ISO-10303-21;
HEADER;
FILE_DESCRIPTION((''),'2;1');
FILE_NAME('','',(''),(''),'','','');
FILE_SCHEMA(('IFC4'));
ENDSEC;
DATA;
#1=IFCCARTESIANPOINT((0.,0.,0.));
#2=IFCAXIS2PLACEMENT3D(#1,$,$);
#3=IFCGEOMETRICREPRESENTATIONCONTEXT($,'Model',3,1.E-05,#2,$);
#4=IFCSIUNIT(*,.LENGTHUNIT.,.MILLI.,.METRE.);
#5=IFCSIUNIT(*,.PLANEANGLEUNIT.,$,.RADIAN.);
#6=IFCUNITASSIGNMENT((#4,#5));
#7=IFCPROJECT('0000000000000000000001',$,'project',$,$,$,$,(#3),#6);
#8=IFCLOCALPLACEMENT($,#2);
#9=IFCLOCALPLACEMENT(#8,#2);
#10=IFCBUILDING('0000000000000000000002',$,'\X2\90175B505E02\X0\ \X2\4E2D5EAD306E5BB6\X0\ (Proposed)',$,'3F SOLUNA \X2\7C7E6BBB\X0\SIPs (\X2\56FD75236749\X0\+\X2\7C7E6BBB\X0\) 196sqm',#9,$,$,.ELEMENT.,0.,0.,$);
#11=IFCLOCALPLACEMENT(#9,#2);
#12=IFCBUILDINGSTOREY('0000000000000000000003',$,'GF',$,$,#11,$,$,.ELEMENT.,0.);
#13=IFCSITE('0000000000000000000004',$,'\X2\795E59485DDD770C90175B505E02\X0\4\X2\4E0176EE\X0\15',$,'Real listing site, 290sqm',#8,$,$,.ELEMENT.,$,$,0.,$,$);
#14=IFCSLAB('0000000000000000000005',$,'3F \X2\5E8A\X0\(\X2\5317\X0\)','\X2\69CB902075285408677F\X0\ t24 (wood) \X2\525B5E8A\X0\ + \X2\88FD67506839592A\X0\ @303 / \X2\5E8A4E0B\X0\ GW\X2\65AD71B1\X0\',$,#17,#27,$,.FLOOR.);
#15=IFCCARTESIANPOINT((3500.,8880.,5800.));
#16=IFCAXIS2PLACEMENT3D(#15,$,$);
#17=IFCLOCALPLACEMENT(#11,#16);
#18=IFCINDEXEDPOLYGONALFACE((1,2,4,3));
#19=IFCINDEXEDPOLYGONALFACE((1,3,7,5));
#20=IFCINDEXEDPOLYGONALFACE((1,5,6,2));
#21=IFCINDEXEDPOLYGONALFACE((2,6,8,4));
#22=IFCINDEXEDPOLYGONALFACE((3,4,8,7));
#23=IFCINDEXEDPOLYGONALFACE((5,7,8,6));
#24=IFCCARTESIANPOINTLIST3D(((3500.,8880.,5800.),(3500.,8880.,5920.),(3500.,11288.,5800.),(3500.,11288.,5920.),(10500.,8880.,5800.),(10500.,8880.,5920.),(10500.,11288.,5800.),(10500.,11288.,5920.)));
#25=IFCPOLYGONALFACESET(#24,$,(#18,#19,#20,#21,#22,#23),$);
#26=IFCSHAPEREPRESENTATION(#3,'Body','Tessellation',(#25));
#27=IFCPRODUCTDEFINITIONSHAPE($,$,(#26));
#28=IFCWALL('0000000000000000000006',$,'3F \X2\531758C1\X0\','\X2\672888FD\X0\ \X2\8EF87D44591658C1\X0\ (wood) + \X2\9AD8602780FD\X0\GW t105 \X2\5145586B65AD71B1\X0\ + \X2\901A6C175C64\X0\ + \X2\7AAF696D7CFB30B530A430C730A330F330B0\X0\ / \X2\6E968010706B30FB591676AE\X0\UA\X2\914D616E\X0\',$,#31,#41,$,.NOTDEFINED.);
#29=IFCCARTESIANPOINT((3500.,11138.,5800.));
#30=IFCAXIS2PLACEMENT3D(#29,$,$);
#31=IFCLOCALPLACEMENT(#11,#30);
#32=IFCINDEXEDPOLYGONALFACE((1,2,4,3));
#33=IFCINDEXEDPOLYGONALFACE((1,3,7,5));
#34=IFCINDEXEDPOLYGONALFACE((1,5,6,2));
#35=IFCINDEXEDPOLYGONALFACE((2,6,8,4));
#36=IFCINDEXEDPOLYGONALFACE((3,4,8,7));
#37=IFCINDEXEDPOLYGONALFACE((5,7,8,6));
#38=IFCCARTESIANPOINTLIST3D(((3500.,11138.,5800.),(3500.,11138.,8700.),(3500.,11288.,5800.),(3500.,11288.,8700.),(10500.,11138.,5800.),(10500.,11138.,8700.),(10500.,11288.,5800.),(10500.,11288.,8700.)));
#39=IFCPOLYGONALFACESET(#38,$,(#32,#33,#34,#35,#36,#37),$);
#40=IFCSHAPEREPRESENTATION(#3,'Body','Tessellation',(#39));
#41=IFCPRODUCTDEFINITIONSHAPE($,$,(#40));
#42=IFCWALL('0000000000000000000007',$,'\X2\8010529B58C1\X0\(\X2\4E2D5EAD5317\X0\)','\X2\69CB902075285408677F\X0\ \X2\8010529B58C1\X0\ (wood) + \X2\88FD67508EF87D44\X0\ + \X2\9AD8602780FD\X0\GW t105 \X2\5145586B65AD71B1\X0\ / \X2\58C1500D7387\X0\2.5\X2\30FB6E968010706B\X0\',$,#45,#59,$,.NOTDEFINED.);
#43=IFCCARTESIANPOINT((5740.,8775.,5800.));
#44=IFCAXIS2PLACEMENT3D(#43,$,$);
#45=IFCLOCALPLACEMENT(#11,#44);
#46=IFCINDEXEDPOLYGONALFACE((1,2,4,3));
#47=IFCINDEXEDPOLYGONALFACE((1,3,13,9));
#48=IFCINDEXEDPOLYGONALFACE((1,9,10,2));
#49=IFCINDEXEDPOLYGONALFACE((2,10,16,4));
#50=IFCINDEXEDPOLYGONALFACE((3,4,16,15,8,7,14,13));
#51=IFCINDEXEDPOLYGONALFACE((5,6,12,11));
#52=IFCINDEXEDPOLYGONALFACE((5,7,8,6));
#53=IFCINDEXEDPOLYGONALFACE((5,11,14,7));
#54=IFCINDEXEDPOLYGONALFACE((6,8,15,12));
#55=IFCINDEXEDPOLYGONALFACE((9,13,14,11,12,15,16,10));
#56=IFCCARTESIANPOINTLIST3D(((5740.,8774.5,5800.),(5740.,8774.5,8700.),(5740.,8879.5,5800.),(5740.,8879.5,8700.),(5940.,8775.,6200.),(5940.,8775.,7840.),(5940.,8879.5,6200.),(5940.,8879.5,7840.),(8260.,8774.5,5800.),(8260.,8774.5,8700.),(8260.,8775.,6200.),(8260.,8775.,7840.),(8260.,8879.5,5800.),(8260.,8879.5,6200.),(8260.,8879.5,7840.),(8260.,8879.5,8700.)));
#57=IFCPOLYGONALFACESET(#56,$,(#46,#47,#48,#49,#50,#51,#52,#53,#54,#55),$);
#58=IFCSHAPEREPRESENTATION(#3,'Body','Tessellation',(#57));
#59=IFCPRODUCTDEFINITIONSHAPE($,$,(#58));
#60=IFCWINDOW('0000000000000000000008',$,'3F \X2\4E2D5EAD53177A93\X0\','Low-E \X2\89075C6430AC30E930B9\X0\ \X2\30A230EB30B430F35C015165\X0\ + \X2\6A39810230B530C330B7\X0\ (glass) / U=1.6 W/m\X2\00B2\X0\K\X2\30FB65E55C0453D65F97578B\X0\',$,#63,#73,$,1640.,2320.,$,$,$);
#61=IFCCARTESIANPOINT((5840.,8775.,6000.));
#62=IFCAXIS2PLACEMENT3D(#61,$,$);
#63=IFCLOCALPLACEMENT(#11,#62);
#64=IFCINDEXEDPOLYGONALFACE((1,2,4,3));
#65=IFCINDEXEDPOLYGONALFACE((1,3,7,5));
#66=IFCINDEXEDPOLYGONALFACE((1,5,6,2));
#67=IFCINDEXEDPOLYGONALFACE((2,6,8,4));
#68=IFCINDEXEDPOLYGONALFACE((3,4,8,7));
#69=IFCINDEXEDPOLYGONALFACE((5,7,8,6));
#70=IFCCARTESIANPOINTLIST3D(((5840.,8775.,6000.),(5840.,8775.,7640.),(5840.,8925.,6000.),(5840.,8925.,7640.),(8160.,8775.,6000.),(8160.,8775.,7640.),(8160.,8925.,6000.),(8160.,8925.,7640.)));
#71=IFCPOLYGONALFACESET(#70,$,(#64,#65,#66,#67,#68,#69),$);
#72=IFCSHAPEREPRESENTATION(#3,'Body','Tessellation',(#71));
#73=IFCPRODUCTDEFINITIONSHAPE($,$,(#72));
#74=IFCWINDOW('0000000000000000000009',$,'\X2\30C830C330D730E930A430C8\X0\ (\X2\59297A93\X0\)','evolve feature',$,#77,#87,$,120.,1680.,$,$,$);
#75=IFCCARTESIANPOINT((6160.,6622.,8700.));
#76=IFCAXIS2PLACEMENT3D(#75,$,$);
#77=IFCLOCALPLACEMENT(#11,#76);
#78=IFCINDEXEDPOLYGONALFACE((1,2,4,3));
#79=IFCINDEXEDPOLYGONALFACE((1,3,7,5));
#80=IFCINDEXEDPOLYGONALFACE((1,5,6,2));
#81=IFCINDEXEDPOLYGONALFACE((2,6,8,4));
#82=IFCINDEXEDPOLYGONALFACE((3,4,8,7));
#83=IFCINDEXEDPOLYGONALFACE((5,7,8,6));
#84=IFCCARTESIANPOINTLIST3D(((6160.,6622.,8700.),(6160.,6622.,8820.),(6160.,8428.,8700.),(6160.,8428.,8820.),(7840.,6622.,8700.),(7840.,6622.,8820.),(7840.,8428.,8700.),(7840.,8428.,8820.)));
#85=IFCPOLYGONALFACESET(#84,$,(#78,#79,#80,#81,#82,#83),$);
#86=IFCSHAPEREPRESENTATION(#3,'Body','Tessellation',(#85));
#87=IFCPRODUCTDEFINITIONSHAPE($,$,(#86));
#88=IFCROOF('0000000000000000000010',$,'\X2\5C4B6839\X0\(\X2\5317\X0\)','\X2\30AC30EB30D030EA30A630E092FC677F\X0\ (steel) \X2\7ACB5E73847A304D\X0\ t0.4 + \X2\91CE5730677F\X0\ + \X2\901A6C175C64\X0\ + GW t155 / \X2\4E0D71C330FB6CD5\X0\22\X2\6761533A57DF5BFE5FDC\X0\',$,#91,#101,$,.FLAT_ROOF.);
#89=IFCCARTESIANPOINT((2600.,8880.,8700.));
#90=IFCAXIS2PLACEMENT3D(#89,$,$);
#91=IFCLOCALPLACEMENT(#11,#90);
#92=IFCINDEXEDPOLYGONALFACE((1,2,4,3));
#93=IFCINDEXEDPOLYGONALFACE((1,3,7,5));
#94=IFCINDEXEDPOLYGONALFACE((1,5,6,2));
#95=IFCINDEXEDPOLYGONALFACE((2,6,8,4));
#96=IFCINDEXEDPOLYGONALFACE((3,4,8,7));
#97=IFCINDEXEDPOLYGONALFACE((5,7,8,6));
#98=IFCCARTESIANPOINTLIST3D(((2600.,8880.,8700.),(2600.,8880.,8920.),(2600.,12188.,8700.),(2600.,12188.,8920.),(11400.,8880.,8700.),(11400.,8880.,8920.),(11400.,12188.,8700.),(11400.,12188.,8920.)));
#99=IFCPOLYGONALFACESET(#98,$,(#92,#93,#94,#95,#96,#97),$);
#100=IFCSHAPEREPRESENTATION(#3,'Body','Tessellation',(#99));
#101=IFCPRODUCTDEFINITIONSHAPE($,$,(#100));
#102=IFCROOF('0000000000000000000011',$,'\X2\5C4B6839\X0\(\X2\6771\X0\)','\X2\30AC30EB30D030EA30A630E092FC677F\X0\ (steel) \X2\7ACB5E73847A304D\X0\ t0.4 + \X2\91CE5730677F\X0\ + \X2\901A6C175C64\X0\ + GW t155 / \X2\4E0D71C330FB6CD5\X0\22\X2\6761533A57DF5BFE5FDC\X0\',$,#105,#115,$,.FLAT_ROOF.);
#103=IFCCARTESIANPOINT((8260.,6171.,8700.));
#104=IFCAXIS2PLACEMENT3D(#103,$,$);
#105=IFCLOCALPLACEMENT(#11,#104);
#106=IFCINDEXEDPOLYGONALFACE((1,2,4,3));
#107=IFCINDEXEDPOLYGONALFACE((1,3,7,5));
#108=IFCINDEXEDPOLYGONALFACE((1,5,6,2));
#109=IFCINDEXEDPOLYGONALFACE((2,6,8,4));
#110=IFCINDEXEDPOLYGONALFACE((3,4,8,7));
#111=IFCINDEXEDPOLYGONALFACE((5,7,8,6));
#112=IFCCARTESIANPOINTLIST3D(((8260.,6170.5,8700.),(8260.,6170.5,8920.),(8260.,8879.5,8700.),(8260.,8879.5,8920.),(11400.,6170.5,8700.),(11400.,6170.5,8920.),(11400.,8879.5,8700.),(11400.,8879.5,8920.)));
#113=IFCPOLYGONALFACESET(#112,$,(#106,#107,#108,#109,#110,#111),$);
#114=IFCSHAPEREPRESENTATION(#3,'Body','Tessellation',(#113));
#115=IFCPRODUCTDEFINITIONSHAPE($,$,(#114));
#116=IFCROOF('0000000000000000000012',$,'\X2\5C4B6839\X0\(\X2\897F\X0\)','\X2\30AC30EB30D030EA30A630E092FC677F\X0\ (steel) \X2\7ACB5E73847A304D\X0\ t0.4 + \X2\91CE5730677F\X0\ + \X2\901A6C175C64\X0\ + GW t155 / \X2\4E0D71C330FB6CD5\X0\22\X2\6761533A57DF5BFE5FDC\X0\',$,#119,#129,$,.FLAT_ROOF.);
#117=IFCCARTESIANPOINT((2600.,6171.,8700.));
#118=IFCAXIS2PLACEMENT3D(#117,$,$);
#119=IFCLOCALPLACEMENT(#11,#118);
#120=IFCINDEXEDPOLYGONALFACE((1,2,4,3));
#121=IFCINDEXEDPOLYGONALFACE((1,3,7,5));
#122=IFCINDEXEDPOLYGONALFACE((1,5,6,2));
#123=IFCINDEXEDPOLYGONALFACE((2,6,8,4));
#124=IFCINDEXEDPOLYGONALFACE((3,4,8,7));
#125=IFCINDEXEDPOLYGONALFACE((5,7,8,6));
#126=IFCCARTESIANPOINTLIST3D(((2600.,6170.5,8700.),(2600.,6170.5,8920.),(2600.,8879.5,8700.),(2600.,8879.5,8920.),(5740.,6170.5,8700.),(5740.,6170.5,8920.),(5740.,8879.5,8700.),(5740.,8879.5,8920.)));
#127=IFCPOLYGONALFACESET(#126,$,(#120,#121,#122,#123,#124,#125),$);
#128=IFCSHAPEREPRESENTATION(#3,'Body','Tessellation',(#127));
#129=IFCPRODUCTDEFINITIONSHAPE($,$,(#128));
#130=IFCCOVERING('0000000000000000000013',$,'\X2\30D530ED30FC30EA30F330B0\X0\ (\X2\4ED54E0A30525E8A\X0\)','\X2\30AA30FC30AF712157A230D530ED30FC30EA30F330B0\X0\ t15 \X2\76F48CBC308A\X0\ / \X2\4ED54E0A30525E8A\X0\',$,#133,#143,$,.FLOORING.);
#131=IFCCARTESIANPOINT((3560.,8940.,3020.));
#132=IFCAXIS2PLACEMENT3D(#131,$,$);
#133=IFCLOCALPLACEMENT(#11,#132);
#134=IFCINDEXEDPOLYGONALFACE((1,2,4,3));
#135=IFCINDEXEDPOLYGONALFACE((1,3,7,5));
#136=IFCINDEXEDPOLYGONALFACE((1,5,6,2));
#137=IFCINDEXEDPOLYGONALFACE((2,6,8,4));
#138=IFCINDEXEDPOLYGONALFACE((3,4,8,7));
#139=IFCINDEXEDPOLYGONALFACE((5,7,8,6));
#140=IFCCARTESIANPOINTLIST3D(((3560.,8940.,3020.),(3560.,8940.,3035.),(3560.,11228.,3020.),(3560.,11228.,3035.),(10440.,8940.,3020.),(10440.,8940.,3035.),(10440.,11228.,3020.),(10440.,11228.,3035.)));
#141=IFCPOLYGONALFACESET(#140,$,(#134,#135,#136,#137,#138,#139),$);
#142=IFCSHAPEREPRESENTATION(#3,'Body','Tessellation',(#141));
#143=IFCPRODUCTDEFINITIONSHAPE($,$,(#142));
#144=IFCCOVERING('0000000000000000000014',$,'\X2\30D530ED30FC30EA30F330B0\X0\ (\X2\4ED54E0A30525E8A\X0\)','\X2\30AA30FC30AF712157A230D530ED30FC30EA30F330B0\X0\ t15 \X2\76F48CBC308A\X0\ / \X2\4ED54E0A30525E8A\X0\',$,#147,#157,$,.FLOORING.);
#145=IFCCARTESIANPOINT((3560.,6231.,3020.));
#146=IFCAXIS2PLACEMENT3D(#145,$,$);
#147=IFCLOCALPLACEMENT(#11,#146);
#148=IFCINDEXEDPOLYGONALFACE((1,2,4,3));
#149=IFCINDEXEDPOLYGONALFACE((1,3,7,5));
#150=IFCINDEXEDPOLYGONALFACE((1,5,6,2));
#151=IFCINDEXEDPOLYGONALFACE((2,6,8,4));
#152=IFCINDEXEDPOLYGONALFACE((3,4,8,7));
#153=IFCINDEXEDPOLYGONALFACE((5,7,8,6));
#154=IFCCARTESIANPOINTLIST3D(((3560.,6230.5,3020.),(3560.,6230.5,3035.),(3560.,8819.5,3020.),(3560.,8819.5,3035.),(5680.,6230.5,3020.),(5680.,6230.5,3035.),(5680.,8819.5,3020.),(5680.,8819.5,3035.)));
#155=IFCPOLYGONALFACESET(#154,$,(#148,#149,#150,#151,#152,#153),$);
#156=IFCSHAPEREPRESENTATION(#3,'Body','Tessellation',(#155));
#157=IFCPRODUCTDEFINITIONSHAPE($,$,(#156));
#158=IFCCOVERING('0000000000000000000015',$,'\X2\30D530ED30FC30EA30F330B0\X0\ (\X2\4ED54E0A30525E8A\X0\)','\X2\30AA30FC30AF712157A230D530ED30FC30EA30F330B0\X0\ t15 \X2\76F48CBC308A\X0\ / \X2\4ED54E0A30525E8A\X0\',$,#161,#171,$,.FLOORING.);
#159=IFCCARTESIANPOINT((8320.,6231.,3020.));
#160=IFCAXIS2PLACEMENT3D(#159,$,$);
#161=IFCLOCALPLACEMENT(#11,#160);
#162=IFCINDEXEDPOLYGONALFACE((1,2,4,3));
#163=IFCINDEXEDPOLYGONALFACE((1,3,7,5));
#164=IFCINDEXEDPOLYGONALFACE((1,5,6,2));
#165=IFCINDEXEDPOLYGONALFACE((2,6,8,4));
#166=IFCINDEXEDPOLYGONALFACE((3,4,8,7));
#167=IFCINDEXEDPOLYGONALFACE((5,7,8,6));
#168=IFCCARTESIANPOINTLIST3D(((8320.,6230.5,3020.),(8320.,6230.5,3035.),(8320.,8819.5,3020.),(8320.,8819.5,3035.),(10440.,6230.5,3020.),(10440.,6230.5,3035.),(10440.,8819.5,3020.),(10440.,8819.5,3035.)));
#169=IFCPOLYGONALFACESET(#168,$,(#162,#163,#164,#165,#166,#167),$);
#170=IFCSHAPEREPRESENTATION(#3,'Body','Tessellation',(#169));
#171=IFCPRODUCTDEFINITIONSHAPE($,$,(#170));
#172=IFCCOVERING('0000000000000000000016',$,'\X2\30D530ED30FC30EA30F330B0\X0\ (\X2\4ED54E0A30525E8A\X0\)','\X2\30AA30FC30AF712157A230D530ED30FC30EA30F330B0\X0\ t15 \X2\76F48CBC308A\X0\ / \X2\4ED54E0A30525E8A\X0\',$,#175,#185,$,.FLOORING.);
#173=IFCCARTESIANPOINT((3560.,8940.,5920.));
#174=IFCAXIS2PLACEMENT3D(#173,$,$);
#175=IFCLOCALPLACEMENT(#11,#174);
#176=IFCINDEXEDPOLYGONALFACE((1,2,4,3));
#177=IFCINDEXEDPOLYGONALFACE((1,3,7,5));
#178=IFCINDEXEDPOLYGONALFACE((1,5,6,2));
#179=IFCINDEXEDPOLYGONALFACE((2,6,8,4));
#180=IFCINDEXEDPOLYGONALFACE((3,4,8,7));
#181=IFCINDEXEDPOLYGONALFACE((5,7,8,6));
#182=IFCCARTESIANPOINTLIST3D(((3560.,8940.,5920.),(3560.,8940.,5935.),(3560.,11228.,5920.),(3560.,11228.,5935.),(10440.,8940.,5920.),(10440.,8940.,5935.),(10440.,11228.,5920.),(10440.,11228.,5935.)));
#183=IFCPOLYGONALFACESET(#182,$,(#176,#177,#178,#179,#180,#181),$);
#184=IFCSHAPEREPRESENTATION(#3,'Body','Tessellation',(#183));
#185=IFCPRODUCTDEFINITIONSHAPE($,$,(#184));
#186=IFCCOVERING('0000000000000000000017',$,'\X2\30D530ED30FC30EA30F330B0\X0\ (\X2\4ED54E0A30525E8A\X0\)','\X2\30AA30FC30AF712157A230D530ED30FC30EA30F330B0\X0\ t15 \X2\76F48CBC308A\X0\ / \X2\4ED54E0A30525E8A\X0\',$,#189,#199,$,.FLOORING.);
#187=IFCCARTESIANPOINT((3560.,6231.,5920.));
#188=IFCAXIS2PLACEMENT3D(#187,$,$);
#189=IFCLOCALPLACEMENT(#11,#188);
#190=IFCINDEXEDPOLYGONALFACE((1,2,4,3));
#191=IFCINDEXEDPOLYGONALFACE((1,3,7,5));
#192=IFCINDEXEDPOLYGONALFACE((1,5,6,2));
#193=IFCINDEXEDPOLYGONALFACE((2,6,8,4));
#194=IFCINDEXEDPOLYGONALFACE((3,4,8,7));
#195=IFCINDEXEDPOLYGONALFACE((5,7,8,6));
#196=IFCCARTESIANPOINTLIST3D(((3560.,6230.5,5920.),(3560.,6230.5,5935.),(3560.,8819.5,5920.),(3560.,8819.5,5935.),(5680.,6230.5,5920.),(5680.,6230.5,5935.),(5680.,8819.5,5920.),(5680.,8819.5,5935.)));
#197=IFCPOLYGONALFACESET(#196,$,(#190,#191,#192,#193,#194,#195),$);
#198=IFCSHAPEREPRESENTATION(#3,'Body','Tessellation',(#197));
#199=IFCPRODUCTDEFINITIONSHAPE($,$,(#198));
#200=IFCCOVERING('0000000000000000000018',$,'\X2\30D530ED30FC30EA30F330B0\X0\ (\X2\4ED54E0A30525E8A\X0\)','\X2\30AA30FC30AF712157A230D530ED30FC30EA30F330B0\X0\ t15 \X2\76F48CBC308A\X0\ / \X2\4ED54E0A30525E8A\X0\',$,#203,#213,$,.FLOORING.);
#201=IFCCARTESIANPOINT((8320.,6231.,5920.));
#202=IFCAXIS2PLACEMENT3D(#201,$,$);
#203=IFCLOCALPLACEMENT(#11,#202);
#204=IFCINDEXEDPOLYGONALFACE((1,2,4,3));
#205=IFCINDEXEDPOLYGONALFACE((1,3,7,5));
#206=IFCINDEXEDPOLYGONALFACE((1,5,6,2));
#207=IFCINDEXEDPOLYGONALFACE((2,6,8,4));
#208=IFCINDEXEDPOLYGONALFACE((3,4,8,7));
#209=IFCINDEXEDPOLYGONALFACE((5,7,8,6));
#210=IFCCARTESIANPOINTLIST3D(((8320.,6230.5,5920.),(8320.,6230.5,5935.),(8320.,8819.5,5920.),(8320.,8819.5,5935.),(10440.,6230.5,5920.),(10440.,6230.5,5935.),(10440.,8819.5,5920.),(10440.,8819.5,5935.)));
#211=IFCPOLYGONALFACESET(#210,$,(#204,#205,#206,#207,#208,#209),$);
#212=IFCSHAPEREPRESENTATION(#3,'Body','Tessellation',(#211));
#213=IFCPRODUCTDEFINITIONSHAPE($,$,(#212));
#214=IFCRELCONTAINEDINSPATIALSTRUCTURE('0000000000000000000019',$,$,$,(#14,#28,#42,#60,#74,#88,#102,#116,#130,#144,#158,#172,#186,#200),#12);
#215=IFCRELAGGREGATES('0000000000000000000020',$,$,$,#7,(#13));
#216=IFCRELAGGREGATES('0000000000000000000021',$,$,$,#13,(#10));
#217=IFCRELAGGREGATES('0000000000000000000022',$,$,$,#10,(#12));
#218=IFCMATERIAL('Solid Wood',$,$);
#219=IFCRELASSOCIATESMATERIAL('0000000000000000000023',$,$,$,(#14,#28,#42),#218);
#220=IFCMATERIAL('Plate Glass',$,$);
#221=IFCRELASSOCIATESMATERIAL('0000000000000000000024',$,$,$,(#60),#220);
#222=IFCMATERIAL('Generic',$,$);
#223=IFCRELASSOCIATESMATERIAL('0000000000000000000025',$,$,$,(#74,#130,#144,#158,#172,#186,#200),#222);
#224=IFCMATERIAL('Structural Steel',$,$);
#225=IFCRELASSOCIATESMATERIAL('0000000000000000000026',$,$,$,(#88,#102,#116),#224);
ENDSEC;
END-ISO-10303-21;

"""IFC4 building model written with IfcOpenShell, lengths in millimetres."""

from ifc_helpers import new_model, si_unit, frame, frame_2d, origin, place, context, project, spatial, rectangle, extrude, material, element, fill, save


model = new_model("IFC4")

# Units and contexts
model_context = context("Model", 3, precision=1e-05, world=origin())
ifc_project = project(units=[si_unit("LENGTHUNIT", "METRE", prefix="MILLI"), si_unit("PLANEANGLEUNIT", "RADIAN")], contexts=[model_context])

# Site, building, storey
site_placement = place(None, origin())
site = spatial("IfcSite", under=ifc_project, at=site_placement, Name="神奈川県逗子市4丁目15", ObjectType="Real listing site, 290sqm", CompositionType="ELEMENT", RefElevation=0.0)
building_placement = place(site_placement, origin())
building = spatial("IfcBuilding", under=site, at=building_placement, Name="逗子市 中庭の家 (Proposed)", ObjectType="3F SOLUNA 籾殻SIPs (国産杉+籾殻) 196sqm", CompositionType="ELEMENT", ElevationOfRefHeight=0.0, ElevationOfTerrain=0.0)
storey_placement = place(building_placement, origin())
storey = spatial("IfcBuildingStorey", under=building, at=storey_placement, Name="GF", CompositionType="ELEMENT", Elevation=0.0)

# Slab
ifc_material_1 = material(Name="Solid Wood")
slab_placement = place(storey_placement, frame((3500.0, 8880.0, 5800.0)))
element("IfcSlab", 1, at=slab_placement, inside=storey, material=ifc_material_1, Name="3F 床(北)", Description="構造用合板 t24 (wood) 剛床 + 製材根太 @303 / 床下 GW断熱", PredefinedType="FLOOR", context=model_context, shape_type="SweptSolid", body=[
    extrude(rectangle(XDim=7000.0, YDim=2408.0, at=frame_2d((3500.0, 1204.0))), frame((3500.0, 8880.0, 5800.0)), (0.0, 0.0, 1.0), 120.0),
])

# Wall
wall_1_placement = place(storey_placement, frame((3500.0, 11138.0, 5800.0)))
element("IfcWall", 2, at=wall_1_placement, inside=storey, material=ifc_material_1, Name="3F 北壁", Description="木製 軸組外壁 (wood) + 高性能GW t105 充填断熱 + 通気層 + 窯業系サイディング / 準耐火・外皮UA配慮", PredefinedType="NOTDEFINED", context=model_context, shape_type="SweptSolid", body=[
    extrude(rectangle(XDim=7000.0, YDim=150.0, at=frame_2d((3500.0, 75.0))), frame((3500.0, 11138.0, 5800.0)), (0.0, 0.0, 1.0), 2900.0),
])

# Wall, opening, window
wall_2_placement = place(storey_placement, frame((5740.0, 8775.0, 5800.0)))
wall_2 = element("IfcWall", 3, at=wall_2_placement, inside=storey, material=ifc_material_1, Name="耐力壁(中庭北)", Description="構造用合板 耐力壁 (wood) + 製材軸組 + 高性能GW t105 充填断熱 / 壁倍率2.5・準耐火", PredefinedType="NOTDEFINED", context=model_context, shape_type="SweptSolid", body=[
    extrude(rectangle(XDim=2520.0, YDim=105.0, at=frame_2d((1260.0, 52.0))), frame((5740.0, 8775.0, 5800.0)), (0.0, 0.0, 1.0), 2900.0),
])
opening_placement = place(storey_placement, frame((5840.0, 8775.0, 6000.0)))
opening = element("IfcOpeningElement", 4, at=opening_placement, cuts=wall_2, PredefinedType="NOTDEFINED", context=model_context, shape_type="SweptSolid", body=[
    extrude(rectangle(XDim=2320.0, YDim=150.0, at=frame_2d((1160.0, 75.0))), frame((5840.0, 8775.0, 6000.0)), (0.0, 0.0, 1.0), 1640.0),
])
ifc_material_2 = material(Name="Plate Glass")
window_1_placement = place(storey_placement, frame((5840.0, 8775.0, 6000.0)))
window_1 = element("IfcWindow", 5, at=window_1_placement, inside=storey, material=ifc_material_2, Name="3F 中庭北窓", Description="Low-E 複層ガラス アルゴン封入 + 樹脂サッシ (glass) / U=1.6 W/m²K・日射取得型", OverallHeight=1640.0, OverallWidth=2320.0, context=model_context, shape_type="SweptSolid", body=[
    extrude(rectangle(XDim=2320.0, YDim=150.0, at=frame_2d((1160.0, 75.0))), frame((5840.0, 8775.0, 6000.0)), (0.0, 0.0, 1.0), 1640.0),
])
fill(opening, window_1)

# Window
ifc_material_3 = material(Name="Generic")
window_2_placement = place(storey_placement, frame((6160.0, 6622.0, 8700.0)))
element("IfcWindow", 6, at=window_2_placement, inside=storey, material=ifc_material_3, Name="トップライト (天窓)", Description="evolve feature", OverallHeight=120.0, OverallWidth=1680.0, context=model_context, shape_type="SweptSolid", body=[
    extrude(rectangle(XDim=1680.0, YDim=1806.0, at=frame_2d((840.0, 903.0))), frame((6160.0, 6622.0, 8700.0)), (0.0, 0.0, 1.0), 120.0),
])

# Roofs
ifc_material_4 = material(Name="Structural Steel")
roof_1_placement = place(storey_placement, frame((2600.0, 8880.0, 8700.0)))
element("IfcRoof", 7, at=roof_1_placement, inside=storey, material=ifc_material_4, Name="屋根(北)", Description="ガルバリウム鋼板 (steel) 立平葺き t0.4 + 野地板 + 通気層 + GW t155 / 不燃・法22条区域対応", PredefinedType="FLAT_ROOF", context=model_context, shape_type="SweptSolid", body=[
    extrude(rectangle(XDim=8800.0, YDim=3308.0, at=frame_2d((4400.0, 1654.0))), frame((2600.0, 8880.0, 8700.0)), (0.0, 0.0, 1.0), 220.0),
])
roof_2_placement = place(storey_placement, frame((8260.0, 6171.0, 8700.0)))
element("IfcRoof", 8, at=roof_2_placement, inside=storey, material=ifc_material_4, Name="屋根(東)", Description="ガルバリウム鋼板 (steel) 立平葺き t0.4 + 野地板 + 通気層 + GW t155 / 不燃・法22条区域対応", PredefinedType="FLAT_ROOF", context=model_context, shape_type="SweptSolid", body=[
    extrude(rectangle(XDim=3140.0, YDim=2709.0, at=frame_2d((1570.0, 1354.0))), frame((8260.0, 6171.0, 8700.0)), (0.0, 0.0, 1.0), 220.0),
])
roof_3_placement = place(storey_placement, frame((2600.0, 6171.0, 8700.0)))
element("IfcRoof", 9, at=roof_3_placement, inside=storey, material=ifc_material_4, Name="屋根(西)", Description="ガルバリウム鋼板 (steel) 立平葺き t0.4 + 野地板 + 通気層 + GW t155 / 不燃・法22条区域対応", PredefinedType="FLAT_ROOF", context=model_context, shape_type="SweptSolid", body=[
    extrude(rectangle(XDim=3140.0, YDim=2709.0, at=frame_2d((1570.0, 1354.0))), frame((2600.0, 6171.0, 8700.0)), (0.0, 0.0, 1.0), 220.0),
])

# Coverings
covering_1_placement = place(storey_placement, frame((3560.0, 8940.0, 3020.0)))
element("IfcCovering", 10, at=covering_1_placement, inside=storey, material=ifc_material_3, Name="フローリング (仕上げ床)", Description="オーク無垢フローリング t15 直貼り / 仕上げ床", PredefinedType="FLOORING", context=model_context, shape_type="SweptSolid", body=[
    extrude(rectangle(XDim=6880.0, YDim=2288.0, at=frame_2d((3440.0, 1144.0))), frame((3560.0, 8940.0, 3020.0)), (0.0, 0.0, 1.0), 15.0),
])
covering_2_placement = place(storey_placement, frame((3560.0, 6231.0, 3020.0)))
element("IfcCovering", 11, at=covering_2_placement, inside=storey, material=ifc_material_3, Name="フローリング (仕上げ床)", Description="オーク無垢フローリング t15 直貼り / 仕上げ床", PredefinedType="FLOORING", context=model_context, shape_type="SweptSolid", body=[
    extrude(rectangle(XDim=2120.0, YDim=2589.0, at=frame_2d((1060.0, 1294.0))), frame((3560.0, 6231.0, 3020.0)), (0.0, 0.0, 1.0), 15.0),
])
covering_3_placement = place(storey_placement, frame((8320.0, 6231.0, 3020.0)))
element("IfcCovering", 12, at=covering_3_placement, inside=storey, material=ifc_material_3, Name="フローリング (仕上げ床)", Description="オーク無垢フローリング t15 直貼り / 仕上げ床", PredefinedType="FLOORING", context=model_context, shape_type="SweptSolid", body=[
    extrude(rectangle(XDim=2120.0, YDim=2589.0, at=frame_2d((1060.0, 1294.0))), frame((8320.0, 6231.0, 3020.0)), (0.0, 0.0, 1.0), 15.0),
])
covering_4_placement = place(storey_placement, frame((3560.0, 8940.0, 5920.0)))
element("IfcCovering", 13, at=covering_4_placement, inside=storey, material=ifc_material_3, Name="フローリング (仕上げ床)", Description="オーク無垢フローリング t15 直貼り / 仕上げ床", PredefinedType="FLOORING", context=model_context, shape_type="SweptSolid", body=[
    extrude(rectangle(XDim=6880.0, YDim=2288.0, at=frame_2d((3440.0, 1144.0))), frame((3560.0, 8940.0, 5920.0)), (0.0, 0.0, 1.0), 15.0),
])
covering_5_placement = place(storey_placement, frame((3560.0, 6231.0, 5920.0)))
element("IfcCovering", 14, at=covering_5_placement, inside=storey, material=ifc_material_3, Name="フローリング (仕上げ床)", Description="オーク無垢フローリング t15 直貼り / 仕上げ床", PredefinedType="FLOORING", context=model_context, shape_type="SweptSolid", body=[
    extrude(rectangle(XDim=2120.0, YDim=2589.0, at=frame_2d((1060.0, 1294.0))), frame((3560.0, 6231.0, 5920.0)), (0.0, 0.0, 1.0), 15.0),
])
covering_6_placement = place(storey_placement, frame((8320.0, 6231.0, 5920.0)))
element("IfcCovering", 15, at=covering_6_placement, inside=storey, material=ifc_material_3, Name="フローリング (仕上げ床)", Description="オーク無垢フローリング t15 直貼り / 仕上げ床", PredefinedType="FLOORING", context=model_context, shape_type="SweptSolid", body=[
    extrude(rectangle(XDim=2120.0, YDim=2589.0, at=frame_2d((1060.0, 1294.0))), frame((8320.0, 6231.0, 5920.0)), (0.0, 0.0, 1.0), 15.0),
])

save(model, "model.ifc")
